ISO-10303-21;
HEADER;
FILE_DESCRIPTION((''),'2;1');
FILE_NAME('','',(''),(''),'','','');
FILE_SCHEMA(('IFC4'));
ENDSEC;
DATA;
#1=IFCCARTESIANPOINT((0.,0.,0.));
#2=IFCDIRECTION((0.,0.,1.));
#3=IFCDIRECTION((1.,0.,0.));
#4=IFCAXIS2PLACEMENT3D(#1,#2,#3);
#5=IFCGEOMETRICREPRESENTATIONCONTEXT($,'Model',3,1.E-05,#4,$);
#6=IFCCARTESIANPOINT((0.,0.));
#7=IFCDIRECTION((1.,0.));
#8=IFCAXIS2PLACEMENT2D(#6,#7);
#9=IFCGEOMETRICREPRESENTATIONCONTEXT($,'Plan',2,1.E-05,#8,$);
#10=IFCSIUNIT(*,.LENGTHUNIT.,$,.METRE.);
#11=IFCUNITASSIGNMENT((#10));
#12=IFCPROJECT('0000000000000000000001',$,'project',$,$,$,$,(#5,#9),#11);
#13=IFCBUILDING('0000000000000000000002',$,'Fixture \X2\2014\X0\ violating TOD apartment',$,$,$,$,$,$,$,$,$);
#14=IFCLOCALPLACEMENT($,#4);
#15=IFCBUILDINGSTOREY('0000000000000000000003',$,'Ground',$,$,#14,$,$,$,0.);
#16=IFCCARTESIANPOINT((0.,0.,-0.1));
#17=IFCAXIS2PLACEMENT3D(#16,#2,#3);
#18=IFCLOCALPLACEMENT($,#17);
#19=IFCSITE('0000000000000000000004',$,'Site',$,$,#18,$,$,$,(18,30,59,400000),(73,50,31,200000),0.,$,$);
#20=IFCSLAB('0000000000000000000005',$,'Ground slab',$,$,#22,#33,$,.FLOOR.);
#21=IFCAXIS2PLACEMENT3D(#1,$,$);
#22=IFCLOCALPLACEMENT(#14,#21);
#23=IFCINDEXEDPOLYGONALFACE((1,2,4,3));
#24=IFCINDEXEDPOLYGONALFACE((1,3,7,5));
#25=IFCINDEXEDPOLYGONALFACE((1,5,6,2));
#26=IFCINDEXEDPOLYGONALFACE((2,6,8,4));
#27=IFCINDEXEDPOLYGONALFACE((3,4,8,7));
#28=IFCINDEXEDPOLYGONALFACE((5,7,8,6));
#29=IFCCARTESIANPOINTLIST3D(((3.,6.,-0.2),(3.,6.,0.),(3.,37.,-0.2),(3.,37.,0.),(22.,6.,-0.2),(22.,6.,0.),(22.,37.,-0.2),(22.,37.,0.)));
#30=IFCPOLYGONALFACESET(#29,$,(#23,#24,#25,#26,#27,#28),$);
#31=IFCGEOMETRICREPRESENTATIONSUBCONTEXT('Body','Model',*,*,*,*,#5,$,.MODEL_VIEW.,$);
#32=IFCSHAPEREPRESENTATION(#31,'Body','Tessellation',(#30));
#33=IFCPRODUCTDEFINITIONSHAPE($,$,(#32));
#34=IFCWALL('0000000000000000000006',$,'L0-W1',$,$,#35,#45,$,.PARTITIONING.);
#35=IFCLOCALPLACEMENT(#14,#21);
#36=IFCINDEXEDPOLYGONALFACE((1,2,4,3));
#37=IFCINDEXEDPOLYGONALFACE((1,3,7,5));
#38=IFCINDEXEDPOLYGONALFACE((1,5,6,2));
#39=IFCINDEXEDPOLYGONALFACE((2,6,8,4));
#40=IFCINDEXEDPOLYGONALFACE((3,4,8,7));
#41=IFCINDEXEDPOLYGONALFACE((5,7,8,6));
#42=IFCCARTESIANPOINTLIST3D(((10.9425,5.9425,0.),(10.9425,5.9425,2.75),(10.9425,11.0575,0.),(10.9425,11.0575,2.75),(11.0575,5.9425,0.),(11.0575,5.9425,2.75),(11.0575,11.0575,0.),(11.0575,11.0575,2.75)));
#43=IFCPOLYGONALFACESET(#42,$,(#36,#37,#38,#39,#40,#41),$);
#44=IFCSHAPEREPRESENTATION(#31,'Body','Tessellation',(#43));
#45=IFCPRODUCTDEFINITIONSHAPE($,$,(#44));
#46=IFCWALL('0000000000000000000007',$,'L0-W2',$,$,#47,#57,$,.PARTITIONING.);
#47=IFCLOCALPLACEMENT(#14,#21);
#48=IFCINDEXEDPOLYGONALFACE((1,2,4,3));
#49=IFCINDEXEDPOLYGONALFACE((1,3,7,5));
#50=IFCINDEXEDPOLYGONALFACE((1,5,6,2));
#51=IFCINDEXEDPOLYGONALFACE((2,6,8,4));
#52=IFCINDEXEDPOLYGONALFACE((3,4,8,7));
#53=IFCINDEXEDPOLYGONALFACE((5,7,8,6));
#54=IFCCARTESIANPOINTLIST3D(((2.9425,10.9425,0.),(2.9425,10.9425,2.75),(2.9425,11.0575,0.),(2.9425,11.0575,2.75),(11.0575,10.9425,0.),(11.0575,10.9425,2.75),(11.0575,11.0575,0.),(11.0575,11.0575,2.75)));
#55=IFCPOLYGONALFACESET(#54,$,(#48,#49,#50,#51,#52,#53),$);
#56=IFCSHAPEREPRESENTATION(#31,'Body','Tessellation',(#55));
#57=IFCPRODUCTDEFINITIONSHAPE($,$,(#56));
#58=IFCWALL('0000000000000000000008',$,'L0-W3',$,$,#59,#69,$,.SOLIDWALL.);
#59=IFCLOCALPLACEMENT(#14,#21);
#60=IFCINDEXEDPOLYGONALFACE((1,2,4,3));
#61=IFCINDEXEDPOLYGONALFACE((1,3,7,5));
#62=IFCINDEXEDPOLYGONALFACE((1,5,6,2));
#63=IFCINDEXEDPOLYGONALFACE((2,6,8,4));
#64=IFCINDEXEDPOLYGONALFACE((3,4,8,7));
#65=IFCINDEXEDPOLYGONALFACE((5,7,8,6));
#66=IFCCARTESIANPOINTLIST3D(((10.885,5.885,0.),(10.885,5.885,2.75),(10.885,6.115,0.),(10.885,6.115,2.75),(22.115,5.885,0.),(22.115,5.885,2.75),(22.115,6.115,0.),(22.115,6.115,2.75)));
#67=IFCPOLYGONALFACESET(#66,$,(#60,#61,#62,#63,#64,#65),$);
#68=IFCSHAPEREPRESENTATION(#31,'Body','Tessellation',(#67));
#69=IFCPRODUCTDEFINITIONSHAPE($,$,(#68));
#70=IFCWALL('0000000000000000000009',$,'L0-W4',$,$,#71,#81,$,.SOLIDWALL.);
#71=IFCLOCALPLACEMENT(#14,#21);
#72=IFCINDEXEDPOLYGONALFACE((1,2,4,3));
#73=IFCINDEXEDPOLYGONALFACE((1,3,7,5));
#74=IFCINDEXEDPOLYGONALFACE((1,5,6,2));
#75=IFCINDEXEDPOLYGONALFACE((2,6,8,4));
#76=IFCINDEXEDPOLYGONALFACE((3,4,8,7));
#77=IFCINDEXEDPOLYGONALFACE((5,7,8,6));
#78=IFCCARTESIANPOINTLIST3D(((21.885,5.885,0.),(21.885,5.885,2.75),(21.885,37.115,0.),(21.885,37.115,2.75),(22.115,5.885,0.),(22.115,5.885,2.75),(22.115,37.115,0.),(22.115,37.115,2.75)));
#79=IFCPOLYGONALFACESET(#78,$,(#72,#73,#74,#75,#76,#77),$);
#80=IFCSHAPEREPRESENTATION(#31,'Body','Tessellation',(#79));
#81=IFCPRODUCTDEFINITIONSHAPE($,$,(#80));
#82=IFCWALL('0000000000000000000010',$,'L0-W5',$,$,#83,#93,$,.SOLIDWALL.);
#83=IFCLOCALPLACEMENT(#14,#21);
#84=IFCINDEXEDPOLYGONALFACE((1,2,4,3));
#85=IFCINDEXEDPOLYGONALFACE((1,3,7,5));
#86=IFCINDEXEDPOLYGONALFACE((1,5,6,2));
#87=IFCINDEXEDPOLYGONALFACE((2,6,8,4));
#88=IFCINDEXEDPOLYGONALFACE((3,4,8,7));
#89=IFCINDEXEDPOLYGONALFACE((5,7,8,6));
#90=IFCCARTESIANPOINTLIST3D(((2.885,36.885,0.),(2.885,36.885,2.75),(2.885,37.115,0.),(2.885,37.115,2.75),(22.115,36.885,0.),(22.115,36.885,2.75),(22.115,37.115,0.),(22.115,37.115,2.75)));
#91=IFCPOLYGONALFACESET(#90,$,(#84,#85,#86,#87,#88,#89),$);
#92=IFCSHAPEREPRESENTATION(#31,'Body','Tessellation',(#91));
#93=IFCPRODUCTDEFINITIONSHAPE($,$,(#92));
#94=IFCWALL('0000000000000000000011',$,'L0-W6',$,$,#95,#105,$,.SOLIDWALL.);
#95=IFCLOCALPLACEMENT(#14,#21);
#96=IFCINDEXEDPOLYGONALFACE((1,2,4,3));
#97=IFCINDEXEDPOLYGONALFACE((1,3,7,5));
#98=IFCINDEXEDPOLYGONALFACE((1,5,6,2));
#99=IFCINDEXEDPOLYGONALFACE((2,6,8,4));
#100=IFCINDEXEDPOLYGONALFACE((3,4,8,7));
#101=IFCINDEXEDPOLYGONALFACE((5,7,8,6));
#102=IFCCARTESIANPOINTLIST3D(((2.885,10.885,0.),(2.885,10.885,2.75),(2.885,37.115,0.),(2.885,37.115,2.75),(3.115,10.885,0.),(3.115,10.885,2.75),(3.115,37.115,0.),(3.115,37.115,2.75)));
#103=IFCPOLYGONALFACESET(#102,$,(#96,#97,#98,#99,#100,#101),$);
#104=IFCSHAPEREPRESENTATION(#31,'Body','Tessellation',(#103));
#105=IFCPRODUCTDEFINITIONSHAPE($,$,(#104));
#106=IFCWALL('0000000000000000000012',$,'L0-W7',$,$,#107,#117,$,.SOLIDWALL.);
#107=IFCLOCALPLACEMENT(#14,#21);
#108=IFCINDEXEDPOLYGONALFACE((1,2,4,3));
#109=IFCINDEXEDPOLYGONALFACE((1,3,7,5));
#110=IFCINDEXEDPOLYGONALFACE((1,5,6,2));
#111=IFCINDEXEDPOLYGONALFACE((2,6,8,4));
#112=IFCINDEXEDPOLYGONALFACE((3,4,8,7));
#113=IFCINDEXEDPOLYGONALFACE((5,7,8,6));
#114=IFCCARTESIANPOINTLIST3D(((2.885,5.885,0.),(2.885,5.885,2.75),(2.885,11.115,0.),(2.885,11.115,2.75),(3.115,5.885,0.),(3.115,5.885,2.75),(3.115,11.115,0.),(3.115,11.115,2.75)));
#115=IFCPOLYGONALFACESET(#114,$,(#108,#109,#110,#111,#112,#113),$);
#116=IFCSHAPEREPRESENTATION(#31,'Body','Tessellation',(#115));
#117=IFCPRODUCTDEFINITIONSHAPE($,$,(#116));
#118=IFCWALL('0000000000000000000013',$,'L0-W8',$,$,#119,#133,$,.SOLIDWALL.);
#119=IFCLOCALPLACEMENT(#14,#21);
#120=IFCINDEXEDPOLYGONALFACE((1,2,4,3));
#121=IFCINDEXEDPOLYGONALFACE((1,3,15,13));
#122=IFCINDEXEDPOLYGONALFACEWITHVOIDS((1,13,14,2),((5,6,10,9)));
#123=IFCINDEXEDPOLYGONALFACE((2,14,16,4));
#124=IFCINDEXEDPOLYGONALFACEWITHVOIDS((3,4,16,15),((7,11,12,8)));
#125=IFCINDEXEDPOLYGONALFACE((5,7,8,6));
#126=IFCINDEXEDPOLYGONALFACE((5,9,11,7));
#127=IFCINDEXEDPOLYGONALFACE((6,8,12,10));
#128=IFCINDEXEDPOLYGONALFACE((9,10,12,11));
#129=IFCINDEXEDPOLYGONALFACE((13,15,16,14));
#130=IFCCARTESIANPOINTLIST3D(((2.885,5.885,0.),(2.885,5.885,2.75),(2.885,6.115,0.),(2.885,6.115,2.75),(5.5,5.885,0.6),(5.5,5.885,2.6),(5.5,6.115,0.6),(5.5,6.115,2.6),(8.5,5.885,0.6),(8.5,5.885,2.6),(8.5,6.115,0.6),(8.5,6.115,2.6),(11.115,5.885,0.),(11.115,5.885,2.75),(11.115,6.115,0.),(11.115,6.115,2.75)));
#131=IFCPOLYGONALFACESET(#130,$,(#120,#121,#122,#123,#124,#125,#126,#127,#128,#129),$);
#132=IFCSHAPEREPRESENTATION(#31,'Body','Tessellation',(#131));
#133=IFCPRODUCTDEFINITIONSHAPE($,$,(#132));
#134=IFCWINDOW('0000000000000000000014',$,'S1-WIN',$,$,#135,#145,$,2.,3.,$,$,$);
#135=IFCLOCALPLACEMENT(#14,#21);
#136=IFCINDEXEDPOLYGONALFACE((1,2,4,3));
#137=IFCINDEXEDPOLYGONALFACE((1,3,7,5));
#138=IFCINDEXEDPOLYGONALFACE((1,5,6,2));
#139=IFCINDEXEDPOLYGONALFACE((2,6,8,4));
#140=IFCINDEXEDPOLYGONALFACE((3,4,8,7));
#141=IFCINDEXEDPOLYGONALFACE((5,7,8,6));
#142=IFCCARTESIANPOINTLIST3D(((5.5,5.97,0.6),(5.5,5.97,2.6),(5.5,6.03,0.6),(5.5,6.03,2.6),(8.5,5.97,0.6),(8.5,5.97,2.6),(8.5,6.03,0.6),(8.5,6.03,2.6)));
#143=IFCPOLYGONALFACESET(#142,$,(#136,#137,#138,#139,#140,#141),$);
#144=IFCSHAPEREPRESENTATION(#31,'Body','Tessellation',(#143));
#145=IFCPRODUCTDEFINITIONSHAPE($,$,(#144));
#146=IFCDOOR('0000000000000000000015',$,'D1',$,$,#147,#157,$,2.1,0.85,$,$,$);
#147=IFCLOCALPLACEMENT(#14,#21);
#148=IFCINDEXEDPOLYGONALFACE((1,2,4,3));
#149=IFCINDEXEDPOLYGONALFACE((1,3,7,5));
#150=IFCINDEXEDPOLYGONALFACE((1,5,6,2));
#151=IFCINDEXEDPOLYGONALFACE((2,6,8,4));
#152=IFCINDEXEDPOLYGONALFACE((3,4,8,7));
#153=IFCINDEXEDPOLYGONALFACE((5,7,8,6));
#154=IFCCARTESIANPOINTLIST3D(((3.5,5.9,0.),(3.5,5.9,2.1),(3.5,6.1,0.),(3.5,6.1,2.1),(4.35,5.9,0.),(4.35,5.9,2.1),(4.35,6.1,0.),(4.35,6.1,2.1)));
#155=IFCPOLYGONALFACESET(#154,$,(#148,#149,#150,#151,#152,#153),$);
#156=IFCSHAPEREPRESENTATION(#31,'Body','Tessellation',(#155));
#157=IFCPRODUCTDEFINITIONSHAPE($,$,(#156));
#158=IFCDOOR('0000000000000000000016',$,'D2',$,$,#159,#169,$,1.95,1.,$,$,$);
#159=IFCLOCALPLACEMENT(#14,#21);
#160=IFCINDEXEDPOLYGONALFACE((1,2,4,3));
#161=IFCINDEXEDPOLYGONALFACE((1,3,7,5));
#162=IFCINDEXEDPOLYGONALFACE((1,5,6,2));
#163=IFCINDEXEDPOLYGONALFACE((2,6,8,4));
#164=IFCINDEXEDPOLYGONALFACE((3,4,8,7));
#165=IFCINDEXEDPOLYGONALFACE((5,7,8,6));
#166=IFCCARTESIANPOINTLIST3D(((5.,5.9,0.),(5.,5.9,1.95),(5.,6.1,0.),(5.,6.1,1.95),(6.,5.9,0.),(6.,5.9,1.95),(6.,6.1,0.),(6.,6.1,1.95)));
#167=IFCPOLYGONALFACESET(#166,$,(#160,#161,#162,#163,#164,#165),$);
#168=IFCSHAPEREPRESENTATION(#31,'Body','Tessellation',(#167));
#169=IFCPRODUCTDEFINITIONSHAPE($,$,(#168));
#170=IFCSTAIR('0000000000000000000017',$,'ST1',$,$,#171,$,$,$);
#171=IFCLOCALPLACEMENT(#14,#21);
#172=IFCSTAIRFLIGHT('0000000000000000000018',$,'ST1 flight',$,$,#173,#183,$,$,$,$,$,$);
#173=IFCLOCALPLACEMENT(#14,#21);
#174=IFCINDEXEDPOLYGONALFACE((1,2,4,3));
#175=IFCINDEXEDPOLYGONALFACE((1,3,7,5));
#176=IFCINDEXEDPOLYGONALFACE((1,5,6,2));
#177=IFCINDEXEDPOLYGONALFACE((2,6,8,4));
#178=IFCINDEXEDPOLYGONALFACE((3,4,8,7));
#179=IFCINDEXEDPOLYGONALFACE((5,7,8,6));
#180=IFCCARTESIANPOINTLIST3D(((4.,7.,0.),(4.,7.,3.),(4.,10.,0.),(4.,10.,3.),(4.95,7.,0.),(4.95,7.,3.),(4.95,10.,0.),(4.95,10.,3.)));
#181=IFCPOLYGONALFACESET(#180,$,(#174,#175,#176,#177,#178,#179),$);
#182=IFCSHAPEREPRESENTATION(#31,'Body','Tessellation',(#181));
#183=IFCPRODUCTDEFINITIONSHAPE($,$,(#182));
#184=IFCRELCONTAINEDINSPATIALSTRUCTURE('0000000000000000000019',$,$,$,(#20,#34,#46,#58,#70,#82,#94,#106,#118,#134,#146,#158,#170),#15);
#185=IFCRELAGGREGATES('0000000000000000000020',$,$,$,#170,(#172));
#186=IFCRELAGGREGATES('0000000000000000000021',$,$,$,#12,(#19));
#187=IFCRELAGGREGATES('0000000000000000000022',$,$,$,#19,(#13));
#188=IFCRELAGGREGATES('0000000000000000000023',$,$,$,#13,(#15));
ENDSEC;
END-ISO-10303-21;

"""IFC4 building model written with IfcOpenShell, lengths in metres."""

from ifc_helpers import new_model, si_unit, frame, origin_with_axes, origin_2d_with_axis, place, context, subcontext, project, spatial, line, indexed_curve, outline, extrude, element, fill, aggregate, save


model = new_model("IFC4")

# Units and contexts
model_context = context("Model", 3, precision=1e-05, world=origin_with_axes())
plan_context = context("Plan", 2, precision=1e-05, world=origin_2d_with_axis())
body_context = subcontext(model_context, "Body", "Model", "MODEL_VIEW")
ifc_project = project(units=[si_unit("LENGTHUNIT", "METRE")], contexts=[model_context, plan_context])

# Site, building, storey
site_placement = place(None, frame((0.0, 0.0, -0.1), z_axis=(0.0, 0.0, 1.0), x_axis=(1.0, 0.0, 0.0)))
site = spatial("IfcSite", under=ifc_project, at=site_placement, Name="Site", RefLatitude=(18, 30, 59, 400000), RefLongitude=(73, 50, 31, 200000), RefElevation=0.0)
building = spatial("IfcBuilding", under=site, Name="Fixture — violating TOD apartment")
storey_placement = place(None, origin_with_axes())
storey = spatial("IfcBuildingStorey", under=building, at=storey_placement, Name="Ground", Elevation=0.0)

# Slab
slab_placement = place(storey_placement, frame((0.0, 0.0, -0.2), z_axis=(0.0, 0.0, 1.0), x_axis=(1.0, 0.0, 0.0)))
element("IfcSlab", 1, at=slab_placement, inside=storey, Name="Ground slab", PredefinedType="FLOOR", context=body_context, shape_type="SweptSolid", body=[
    extrude(outline(indexed_curve([(3.0, 6.0), (22.0, 6.0), (22.0, 37.0), (3.0, 37.0)], segments=[line(1, 2, 3, 4, 1)])), origin_with_axes(), (0.0, 0.0, 1.0), 0.2),
])

# Walls
wall_1_placement = place(storey_placement, origin_with_axes())
element("IfcWall", 2, at=wall_1_placement, inside=storey, Name="L0-W1", PredefinedType="PARTITIONING", context=body_context, shape_type="SweptSolid", body=[
    extrude(outline(indexed_curve([(10.9425, 5.9425), (10.9425, 11.0575), (11.0575, 11.0575), (11.0575, 5.9425)], segments=[line(1, 2, 3, 4, 1)])), origin_with_axes(), (0.0, 0.0, 1.0), 2.75),
])
wall_2_placement = place(storey_placement, origin_with_axes())
element("IfcWall", 3, at=wall_2_placement, inside=storey, Name="L0-W2", PredefinedType="PARTITIONING", context=body_context, shape_type="SweptSolid", body=[
    extrude(outline(indexed_curve([(11.0575, 10.9425), (2.9425, 10.9425), (2.9425, 11.0575), (11.0575, 11.0575)], segments=[line(1, 2, 3, 4, 1)])), origin_with_axes(), (0.0, 0.0, 1.0), 2.75),
])
wall_3_placement = place(storey_placement, origin_with_axes())
element("IfcWall", 4, at=wall_3_placement, inside=storey, Name="L0-W3", PredefinedType="SOLIDWALL", context=body_context, shape_type="SweptSolid", body=[
    extrude(outline(indexed_curve([(10.885, 6.115), (22.115, 6.115), (22.115, 5.885), (10.885, 5.885)], segments=[line(1, 2, 3, 4, 1)])), origin_with_axes(), (0.0, 0.0, 1.0), 2.75),
])
wall_4_placement = place(storey_placement, origin_with_axes())
element("IfcWall", 5, at=wall_4_placement, inside=storey, Name="L0-W4", PredefinedType="SOLIDWALL", context=body_context, shape_type="SweptSolid", body=[
    extrude(outline(indexed_curve([(21.885, 5.885), (21.885, 37.115), (22.115, 37.115), (22.115, 5.885)], segments=[line(1, 2, 3, 4, 1)])), origin_with_axes(), (0.0, 0.0, 1.0), 2.75),
])
wall_5_placement = place(storey_placement, origin_with_axes())
element("IfcWall", 6, at=wall_5_placement, inside=storey, Name="L0-W5", PredefinedType="SOLIDWALL", context=body_context, shape_type="SweptSolid", body=[
    extrude(outline(indexed_curve([(22.115, 36.885), (2.885, 36.885), (2.885, 37.115), (22.115, 37.115)], segments=[line(1, 2, 3, 4, 1)])), origin_with_axes(), (0.0, 0.0, 1.0), 2.75),
])
wall_6_placement = place(storey_placement, origin_with_axes())
element("IfcWall", 7, at=wall_6_placement, inside=storey, Name="L0-W6", PredefinedType="SOLIDWALL", context=body_context, shape_type="SweptSolid", body=[
    extrude(outline(indexed_curve([(3.115, 37.115), (3.115, 10.885), (2.885, 10.885), (2.885, 37.115)], segments=[line(1, 2, 3, 4, 1)])), origin_with_axes(), (0.0, 0.0, 1.0), 2.75),
])
wall_7_placement = place(storey_placement, origin_with_axes())
element("IfcWall", 8, at=wall_7_placement, inside=storey, Name="L0-W7", PredefinedType="SOLIDWALL", context=body_context, shape_type="SweptSolid", body=[
    extrude(outline(indexed_curve([(3.115, 11.115), (3.115, 5.885), (2.885, 5.885), (2.885, 11.115)], segments=[line(1, 2, 3, 4, 1)])), origin_with_axes(), (0.0, 0.0, 1.0), 2.75),
])

# Wall, opening, window
wall_8_placement = place(storey_placement, origin_with_axes())
wall_8 = element("IfcWall", 9, at=wall_8_placement, inside=storey, Name="L0-W8", PredefinedType="SOLIDWALL", context=body_context, shape_type="SweptSolid", body=[
    extrude(outline(indexed_curve([(2.885, 6.115), (11.115, 6.115), (11.115, 5.885), (2.885, 5.885)], segments=[line(1, 2, 3, 4, 1)])), origin_with_axes(), (0.0, 0.0, 1.0), 2.75),
])
opening_placement = place(wall_8_placement, origin_with_axes())
opening = element("IfcOpeningElement", 10, at=opening_placement, cuts=wall_8, context=body_context, shape_type="SweptSolid", body=[
    extrude(outline(indexed_curve([(5.5, 6.165), (8.5, 6.165), (8.5, 5.835), (5.5, 5.835)], segments=[line(1, 2, 3, 4, 1)])), frame((0.0, 0.0, 0.6), z_axis=(0.0, 0.0, 1.0), x_axis=(1.0, 0.0, 0.0)), (0.0, 0.0, 1.0), 2.0),
])
window_placement = place(storey_placement, origin_with_axes())
window = element("IfcWindow", 11, at=window_placement, inside=storey, Name="S1-WIN", OverallHeight=2.0, OverallWidth=3.0, context=body_context, shape_type="SweptSolid", body=[
    extrude(outline(indexed_curve([(5.5, 6.03), (8.5, 6.03), (8.5, 5.97), (5.5, 5.97)], segments=[line(1, 2, 3, 4, 1)])), frame((0.0, 0.0, 0.6), z_axis=(0.0, 0.0, 1.0), x_axis=(1.0, 0.0, 0.0)), (0.0, 0.0, 1.0), 2.0),
])
fill(opening, window)

# Doors
door_1_placement = place(storey_placement, frame((3.5, 5.9, 0.0), z_axis=(0.0, 0.0, 1.0), x_axis=(1.0, 0.0, 0.0)))
element("IfcDoor", 12, at=door_1_placement, inside=storey, Name="D1", OverallHeight=2.1, OverallWidth=0.85, context=body_context, shape_type="SweptSolid", body=[
    extrude(outline(indexed_curve([(0.0, 0.0), (0.85, 0.0), (0.85, 0.2), (0.0, 0.2)], segments=[line(1, 2, 3, 4, 1)])), origin_with_axes(), (0.0, 0.0, 1.0), 2.1),
])
door_2_placement = place(storey_placement, frame((5.0, 5.9, 0.0), z_axis=(0.0, 0.0, 1.0), x_axis=(1.0, 0.0, 0.0)))
element("IfcDoor", 13, at=door_2_placement, inside=storey, Name="D2", OverallHeight=1.95, OverallWidth=1.0, context=body_context, shape_type="SweptSolid", body=[
    extrude(outline(indexed_curve([(0.0, 0.0), (1.0, 0.0), (1.0, 0.2), (0.0, 0.2)], segments=[line(1, 2, 3, 4, 1)])), origin_with_axes(), (0.0, 0.0, 1.0), 1.95),
])

# Stair, stair flight
stair = element("IfcStair", 14, inside=storey, Name="ST1")
stair_flight_placement = place(None, frame((4.0, 7.0, 0.0), z_axis=(0.0, 0.0, 1.0), x_axis=(1.0, 0.0, 0.0)))
stair_flight = element("IfcStairFlight", 15, at=stair_flight_placement, Name="ST1 flight", context=body_context, shape_type="SweptSolid", body=[
    extrude(outline(indexed_curve([(0.0, 0.0), (0.95, 0.0), (0.95, 3.0), (0.0, 3.0)], segments=[line(1, 2, 3, 4, 1)])), origin_with_axes(), (0.0, 0.0, 1.0), 3.0),
])
aggregate(stair, [stair_flight])

save(model, "model.ifc")
